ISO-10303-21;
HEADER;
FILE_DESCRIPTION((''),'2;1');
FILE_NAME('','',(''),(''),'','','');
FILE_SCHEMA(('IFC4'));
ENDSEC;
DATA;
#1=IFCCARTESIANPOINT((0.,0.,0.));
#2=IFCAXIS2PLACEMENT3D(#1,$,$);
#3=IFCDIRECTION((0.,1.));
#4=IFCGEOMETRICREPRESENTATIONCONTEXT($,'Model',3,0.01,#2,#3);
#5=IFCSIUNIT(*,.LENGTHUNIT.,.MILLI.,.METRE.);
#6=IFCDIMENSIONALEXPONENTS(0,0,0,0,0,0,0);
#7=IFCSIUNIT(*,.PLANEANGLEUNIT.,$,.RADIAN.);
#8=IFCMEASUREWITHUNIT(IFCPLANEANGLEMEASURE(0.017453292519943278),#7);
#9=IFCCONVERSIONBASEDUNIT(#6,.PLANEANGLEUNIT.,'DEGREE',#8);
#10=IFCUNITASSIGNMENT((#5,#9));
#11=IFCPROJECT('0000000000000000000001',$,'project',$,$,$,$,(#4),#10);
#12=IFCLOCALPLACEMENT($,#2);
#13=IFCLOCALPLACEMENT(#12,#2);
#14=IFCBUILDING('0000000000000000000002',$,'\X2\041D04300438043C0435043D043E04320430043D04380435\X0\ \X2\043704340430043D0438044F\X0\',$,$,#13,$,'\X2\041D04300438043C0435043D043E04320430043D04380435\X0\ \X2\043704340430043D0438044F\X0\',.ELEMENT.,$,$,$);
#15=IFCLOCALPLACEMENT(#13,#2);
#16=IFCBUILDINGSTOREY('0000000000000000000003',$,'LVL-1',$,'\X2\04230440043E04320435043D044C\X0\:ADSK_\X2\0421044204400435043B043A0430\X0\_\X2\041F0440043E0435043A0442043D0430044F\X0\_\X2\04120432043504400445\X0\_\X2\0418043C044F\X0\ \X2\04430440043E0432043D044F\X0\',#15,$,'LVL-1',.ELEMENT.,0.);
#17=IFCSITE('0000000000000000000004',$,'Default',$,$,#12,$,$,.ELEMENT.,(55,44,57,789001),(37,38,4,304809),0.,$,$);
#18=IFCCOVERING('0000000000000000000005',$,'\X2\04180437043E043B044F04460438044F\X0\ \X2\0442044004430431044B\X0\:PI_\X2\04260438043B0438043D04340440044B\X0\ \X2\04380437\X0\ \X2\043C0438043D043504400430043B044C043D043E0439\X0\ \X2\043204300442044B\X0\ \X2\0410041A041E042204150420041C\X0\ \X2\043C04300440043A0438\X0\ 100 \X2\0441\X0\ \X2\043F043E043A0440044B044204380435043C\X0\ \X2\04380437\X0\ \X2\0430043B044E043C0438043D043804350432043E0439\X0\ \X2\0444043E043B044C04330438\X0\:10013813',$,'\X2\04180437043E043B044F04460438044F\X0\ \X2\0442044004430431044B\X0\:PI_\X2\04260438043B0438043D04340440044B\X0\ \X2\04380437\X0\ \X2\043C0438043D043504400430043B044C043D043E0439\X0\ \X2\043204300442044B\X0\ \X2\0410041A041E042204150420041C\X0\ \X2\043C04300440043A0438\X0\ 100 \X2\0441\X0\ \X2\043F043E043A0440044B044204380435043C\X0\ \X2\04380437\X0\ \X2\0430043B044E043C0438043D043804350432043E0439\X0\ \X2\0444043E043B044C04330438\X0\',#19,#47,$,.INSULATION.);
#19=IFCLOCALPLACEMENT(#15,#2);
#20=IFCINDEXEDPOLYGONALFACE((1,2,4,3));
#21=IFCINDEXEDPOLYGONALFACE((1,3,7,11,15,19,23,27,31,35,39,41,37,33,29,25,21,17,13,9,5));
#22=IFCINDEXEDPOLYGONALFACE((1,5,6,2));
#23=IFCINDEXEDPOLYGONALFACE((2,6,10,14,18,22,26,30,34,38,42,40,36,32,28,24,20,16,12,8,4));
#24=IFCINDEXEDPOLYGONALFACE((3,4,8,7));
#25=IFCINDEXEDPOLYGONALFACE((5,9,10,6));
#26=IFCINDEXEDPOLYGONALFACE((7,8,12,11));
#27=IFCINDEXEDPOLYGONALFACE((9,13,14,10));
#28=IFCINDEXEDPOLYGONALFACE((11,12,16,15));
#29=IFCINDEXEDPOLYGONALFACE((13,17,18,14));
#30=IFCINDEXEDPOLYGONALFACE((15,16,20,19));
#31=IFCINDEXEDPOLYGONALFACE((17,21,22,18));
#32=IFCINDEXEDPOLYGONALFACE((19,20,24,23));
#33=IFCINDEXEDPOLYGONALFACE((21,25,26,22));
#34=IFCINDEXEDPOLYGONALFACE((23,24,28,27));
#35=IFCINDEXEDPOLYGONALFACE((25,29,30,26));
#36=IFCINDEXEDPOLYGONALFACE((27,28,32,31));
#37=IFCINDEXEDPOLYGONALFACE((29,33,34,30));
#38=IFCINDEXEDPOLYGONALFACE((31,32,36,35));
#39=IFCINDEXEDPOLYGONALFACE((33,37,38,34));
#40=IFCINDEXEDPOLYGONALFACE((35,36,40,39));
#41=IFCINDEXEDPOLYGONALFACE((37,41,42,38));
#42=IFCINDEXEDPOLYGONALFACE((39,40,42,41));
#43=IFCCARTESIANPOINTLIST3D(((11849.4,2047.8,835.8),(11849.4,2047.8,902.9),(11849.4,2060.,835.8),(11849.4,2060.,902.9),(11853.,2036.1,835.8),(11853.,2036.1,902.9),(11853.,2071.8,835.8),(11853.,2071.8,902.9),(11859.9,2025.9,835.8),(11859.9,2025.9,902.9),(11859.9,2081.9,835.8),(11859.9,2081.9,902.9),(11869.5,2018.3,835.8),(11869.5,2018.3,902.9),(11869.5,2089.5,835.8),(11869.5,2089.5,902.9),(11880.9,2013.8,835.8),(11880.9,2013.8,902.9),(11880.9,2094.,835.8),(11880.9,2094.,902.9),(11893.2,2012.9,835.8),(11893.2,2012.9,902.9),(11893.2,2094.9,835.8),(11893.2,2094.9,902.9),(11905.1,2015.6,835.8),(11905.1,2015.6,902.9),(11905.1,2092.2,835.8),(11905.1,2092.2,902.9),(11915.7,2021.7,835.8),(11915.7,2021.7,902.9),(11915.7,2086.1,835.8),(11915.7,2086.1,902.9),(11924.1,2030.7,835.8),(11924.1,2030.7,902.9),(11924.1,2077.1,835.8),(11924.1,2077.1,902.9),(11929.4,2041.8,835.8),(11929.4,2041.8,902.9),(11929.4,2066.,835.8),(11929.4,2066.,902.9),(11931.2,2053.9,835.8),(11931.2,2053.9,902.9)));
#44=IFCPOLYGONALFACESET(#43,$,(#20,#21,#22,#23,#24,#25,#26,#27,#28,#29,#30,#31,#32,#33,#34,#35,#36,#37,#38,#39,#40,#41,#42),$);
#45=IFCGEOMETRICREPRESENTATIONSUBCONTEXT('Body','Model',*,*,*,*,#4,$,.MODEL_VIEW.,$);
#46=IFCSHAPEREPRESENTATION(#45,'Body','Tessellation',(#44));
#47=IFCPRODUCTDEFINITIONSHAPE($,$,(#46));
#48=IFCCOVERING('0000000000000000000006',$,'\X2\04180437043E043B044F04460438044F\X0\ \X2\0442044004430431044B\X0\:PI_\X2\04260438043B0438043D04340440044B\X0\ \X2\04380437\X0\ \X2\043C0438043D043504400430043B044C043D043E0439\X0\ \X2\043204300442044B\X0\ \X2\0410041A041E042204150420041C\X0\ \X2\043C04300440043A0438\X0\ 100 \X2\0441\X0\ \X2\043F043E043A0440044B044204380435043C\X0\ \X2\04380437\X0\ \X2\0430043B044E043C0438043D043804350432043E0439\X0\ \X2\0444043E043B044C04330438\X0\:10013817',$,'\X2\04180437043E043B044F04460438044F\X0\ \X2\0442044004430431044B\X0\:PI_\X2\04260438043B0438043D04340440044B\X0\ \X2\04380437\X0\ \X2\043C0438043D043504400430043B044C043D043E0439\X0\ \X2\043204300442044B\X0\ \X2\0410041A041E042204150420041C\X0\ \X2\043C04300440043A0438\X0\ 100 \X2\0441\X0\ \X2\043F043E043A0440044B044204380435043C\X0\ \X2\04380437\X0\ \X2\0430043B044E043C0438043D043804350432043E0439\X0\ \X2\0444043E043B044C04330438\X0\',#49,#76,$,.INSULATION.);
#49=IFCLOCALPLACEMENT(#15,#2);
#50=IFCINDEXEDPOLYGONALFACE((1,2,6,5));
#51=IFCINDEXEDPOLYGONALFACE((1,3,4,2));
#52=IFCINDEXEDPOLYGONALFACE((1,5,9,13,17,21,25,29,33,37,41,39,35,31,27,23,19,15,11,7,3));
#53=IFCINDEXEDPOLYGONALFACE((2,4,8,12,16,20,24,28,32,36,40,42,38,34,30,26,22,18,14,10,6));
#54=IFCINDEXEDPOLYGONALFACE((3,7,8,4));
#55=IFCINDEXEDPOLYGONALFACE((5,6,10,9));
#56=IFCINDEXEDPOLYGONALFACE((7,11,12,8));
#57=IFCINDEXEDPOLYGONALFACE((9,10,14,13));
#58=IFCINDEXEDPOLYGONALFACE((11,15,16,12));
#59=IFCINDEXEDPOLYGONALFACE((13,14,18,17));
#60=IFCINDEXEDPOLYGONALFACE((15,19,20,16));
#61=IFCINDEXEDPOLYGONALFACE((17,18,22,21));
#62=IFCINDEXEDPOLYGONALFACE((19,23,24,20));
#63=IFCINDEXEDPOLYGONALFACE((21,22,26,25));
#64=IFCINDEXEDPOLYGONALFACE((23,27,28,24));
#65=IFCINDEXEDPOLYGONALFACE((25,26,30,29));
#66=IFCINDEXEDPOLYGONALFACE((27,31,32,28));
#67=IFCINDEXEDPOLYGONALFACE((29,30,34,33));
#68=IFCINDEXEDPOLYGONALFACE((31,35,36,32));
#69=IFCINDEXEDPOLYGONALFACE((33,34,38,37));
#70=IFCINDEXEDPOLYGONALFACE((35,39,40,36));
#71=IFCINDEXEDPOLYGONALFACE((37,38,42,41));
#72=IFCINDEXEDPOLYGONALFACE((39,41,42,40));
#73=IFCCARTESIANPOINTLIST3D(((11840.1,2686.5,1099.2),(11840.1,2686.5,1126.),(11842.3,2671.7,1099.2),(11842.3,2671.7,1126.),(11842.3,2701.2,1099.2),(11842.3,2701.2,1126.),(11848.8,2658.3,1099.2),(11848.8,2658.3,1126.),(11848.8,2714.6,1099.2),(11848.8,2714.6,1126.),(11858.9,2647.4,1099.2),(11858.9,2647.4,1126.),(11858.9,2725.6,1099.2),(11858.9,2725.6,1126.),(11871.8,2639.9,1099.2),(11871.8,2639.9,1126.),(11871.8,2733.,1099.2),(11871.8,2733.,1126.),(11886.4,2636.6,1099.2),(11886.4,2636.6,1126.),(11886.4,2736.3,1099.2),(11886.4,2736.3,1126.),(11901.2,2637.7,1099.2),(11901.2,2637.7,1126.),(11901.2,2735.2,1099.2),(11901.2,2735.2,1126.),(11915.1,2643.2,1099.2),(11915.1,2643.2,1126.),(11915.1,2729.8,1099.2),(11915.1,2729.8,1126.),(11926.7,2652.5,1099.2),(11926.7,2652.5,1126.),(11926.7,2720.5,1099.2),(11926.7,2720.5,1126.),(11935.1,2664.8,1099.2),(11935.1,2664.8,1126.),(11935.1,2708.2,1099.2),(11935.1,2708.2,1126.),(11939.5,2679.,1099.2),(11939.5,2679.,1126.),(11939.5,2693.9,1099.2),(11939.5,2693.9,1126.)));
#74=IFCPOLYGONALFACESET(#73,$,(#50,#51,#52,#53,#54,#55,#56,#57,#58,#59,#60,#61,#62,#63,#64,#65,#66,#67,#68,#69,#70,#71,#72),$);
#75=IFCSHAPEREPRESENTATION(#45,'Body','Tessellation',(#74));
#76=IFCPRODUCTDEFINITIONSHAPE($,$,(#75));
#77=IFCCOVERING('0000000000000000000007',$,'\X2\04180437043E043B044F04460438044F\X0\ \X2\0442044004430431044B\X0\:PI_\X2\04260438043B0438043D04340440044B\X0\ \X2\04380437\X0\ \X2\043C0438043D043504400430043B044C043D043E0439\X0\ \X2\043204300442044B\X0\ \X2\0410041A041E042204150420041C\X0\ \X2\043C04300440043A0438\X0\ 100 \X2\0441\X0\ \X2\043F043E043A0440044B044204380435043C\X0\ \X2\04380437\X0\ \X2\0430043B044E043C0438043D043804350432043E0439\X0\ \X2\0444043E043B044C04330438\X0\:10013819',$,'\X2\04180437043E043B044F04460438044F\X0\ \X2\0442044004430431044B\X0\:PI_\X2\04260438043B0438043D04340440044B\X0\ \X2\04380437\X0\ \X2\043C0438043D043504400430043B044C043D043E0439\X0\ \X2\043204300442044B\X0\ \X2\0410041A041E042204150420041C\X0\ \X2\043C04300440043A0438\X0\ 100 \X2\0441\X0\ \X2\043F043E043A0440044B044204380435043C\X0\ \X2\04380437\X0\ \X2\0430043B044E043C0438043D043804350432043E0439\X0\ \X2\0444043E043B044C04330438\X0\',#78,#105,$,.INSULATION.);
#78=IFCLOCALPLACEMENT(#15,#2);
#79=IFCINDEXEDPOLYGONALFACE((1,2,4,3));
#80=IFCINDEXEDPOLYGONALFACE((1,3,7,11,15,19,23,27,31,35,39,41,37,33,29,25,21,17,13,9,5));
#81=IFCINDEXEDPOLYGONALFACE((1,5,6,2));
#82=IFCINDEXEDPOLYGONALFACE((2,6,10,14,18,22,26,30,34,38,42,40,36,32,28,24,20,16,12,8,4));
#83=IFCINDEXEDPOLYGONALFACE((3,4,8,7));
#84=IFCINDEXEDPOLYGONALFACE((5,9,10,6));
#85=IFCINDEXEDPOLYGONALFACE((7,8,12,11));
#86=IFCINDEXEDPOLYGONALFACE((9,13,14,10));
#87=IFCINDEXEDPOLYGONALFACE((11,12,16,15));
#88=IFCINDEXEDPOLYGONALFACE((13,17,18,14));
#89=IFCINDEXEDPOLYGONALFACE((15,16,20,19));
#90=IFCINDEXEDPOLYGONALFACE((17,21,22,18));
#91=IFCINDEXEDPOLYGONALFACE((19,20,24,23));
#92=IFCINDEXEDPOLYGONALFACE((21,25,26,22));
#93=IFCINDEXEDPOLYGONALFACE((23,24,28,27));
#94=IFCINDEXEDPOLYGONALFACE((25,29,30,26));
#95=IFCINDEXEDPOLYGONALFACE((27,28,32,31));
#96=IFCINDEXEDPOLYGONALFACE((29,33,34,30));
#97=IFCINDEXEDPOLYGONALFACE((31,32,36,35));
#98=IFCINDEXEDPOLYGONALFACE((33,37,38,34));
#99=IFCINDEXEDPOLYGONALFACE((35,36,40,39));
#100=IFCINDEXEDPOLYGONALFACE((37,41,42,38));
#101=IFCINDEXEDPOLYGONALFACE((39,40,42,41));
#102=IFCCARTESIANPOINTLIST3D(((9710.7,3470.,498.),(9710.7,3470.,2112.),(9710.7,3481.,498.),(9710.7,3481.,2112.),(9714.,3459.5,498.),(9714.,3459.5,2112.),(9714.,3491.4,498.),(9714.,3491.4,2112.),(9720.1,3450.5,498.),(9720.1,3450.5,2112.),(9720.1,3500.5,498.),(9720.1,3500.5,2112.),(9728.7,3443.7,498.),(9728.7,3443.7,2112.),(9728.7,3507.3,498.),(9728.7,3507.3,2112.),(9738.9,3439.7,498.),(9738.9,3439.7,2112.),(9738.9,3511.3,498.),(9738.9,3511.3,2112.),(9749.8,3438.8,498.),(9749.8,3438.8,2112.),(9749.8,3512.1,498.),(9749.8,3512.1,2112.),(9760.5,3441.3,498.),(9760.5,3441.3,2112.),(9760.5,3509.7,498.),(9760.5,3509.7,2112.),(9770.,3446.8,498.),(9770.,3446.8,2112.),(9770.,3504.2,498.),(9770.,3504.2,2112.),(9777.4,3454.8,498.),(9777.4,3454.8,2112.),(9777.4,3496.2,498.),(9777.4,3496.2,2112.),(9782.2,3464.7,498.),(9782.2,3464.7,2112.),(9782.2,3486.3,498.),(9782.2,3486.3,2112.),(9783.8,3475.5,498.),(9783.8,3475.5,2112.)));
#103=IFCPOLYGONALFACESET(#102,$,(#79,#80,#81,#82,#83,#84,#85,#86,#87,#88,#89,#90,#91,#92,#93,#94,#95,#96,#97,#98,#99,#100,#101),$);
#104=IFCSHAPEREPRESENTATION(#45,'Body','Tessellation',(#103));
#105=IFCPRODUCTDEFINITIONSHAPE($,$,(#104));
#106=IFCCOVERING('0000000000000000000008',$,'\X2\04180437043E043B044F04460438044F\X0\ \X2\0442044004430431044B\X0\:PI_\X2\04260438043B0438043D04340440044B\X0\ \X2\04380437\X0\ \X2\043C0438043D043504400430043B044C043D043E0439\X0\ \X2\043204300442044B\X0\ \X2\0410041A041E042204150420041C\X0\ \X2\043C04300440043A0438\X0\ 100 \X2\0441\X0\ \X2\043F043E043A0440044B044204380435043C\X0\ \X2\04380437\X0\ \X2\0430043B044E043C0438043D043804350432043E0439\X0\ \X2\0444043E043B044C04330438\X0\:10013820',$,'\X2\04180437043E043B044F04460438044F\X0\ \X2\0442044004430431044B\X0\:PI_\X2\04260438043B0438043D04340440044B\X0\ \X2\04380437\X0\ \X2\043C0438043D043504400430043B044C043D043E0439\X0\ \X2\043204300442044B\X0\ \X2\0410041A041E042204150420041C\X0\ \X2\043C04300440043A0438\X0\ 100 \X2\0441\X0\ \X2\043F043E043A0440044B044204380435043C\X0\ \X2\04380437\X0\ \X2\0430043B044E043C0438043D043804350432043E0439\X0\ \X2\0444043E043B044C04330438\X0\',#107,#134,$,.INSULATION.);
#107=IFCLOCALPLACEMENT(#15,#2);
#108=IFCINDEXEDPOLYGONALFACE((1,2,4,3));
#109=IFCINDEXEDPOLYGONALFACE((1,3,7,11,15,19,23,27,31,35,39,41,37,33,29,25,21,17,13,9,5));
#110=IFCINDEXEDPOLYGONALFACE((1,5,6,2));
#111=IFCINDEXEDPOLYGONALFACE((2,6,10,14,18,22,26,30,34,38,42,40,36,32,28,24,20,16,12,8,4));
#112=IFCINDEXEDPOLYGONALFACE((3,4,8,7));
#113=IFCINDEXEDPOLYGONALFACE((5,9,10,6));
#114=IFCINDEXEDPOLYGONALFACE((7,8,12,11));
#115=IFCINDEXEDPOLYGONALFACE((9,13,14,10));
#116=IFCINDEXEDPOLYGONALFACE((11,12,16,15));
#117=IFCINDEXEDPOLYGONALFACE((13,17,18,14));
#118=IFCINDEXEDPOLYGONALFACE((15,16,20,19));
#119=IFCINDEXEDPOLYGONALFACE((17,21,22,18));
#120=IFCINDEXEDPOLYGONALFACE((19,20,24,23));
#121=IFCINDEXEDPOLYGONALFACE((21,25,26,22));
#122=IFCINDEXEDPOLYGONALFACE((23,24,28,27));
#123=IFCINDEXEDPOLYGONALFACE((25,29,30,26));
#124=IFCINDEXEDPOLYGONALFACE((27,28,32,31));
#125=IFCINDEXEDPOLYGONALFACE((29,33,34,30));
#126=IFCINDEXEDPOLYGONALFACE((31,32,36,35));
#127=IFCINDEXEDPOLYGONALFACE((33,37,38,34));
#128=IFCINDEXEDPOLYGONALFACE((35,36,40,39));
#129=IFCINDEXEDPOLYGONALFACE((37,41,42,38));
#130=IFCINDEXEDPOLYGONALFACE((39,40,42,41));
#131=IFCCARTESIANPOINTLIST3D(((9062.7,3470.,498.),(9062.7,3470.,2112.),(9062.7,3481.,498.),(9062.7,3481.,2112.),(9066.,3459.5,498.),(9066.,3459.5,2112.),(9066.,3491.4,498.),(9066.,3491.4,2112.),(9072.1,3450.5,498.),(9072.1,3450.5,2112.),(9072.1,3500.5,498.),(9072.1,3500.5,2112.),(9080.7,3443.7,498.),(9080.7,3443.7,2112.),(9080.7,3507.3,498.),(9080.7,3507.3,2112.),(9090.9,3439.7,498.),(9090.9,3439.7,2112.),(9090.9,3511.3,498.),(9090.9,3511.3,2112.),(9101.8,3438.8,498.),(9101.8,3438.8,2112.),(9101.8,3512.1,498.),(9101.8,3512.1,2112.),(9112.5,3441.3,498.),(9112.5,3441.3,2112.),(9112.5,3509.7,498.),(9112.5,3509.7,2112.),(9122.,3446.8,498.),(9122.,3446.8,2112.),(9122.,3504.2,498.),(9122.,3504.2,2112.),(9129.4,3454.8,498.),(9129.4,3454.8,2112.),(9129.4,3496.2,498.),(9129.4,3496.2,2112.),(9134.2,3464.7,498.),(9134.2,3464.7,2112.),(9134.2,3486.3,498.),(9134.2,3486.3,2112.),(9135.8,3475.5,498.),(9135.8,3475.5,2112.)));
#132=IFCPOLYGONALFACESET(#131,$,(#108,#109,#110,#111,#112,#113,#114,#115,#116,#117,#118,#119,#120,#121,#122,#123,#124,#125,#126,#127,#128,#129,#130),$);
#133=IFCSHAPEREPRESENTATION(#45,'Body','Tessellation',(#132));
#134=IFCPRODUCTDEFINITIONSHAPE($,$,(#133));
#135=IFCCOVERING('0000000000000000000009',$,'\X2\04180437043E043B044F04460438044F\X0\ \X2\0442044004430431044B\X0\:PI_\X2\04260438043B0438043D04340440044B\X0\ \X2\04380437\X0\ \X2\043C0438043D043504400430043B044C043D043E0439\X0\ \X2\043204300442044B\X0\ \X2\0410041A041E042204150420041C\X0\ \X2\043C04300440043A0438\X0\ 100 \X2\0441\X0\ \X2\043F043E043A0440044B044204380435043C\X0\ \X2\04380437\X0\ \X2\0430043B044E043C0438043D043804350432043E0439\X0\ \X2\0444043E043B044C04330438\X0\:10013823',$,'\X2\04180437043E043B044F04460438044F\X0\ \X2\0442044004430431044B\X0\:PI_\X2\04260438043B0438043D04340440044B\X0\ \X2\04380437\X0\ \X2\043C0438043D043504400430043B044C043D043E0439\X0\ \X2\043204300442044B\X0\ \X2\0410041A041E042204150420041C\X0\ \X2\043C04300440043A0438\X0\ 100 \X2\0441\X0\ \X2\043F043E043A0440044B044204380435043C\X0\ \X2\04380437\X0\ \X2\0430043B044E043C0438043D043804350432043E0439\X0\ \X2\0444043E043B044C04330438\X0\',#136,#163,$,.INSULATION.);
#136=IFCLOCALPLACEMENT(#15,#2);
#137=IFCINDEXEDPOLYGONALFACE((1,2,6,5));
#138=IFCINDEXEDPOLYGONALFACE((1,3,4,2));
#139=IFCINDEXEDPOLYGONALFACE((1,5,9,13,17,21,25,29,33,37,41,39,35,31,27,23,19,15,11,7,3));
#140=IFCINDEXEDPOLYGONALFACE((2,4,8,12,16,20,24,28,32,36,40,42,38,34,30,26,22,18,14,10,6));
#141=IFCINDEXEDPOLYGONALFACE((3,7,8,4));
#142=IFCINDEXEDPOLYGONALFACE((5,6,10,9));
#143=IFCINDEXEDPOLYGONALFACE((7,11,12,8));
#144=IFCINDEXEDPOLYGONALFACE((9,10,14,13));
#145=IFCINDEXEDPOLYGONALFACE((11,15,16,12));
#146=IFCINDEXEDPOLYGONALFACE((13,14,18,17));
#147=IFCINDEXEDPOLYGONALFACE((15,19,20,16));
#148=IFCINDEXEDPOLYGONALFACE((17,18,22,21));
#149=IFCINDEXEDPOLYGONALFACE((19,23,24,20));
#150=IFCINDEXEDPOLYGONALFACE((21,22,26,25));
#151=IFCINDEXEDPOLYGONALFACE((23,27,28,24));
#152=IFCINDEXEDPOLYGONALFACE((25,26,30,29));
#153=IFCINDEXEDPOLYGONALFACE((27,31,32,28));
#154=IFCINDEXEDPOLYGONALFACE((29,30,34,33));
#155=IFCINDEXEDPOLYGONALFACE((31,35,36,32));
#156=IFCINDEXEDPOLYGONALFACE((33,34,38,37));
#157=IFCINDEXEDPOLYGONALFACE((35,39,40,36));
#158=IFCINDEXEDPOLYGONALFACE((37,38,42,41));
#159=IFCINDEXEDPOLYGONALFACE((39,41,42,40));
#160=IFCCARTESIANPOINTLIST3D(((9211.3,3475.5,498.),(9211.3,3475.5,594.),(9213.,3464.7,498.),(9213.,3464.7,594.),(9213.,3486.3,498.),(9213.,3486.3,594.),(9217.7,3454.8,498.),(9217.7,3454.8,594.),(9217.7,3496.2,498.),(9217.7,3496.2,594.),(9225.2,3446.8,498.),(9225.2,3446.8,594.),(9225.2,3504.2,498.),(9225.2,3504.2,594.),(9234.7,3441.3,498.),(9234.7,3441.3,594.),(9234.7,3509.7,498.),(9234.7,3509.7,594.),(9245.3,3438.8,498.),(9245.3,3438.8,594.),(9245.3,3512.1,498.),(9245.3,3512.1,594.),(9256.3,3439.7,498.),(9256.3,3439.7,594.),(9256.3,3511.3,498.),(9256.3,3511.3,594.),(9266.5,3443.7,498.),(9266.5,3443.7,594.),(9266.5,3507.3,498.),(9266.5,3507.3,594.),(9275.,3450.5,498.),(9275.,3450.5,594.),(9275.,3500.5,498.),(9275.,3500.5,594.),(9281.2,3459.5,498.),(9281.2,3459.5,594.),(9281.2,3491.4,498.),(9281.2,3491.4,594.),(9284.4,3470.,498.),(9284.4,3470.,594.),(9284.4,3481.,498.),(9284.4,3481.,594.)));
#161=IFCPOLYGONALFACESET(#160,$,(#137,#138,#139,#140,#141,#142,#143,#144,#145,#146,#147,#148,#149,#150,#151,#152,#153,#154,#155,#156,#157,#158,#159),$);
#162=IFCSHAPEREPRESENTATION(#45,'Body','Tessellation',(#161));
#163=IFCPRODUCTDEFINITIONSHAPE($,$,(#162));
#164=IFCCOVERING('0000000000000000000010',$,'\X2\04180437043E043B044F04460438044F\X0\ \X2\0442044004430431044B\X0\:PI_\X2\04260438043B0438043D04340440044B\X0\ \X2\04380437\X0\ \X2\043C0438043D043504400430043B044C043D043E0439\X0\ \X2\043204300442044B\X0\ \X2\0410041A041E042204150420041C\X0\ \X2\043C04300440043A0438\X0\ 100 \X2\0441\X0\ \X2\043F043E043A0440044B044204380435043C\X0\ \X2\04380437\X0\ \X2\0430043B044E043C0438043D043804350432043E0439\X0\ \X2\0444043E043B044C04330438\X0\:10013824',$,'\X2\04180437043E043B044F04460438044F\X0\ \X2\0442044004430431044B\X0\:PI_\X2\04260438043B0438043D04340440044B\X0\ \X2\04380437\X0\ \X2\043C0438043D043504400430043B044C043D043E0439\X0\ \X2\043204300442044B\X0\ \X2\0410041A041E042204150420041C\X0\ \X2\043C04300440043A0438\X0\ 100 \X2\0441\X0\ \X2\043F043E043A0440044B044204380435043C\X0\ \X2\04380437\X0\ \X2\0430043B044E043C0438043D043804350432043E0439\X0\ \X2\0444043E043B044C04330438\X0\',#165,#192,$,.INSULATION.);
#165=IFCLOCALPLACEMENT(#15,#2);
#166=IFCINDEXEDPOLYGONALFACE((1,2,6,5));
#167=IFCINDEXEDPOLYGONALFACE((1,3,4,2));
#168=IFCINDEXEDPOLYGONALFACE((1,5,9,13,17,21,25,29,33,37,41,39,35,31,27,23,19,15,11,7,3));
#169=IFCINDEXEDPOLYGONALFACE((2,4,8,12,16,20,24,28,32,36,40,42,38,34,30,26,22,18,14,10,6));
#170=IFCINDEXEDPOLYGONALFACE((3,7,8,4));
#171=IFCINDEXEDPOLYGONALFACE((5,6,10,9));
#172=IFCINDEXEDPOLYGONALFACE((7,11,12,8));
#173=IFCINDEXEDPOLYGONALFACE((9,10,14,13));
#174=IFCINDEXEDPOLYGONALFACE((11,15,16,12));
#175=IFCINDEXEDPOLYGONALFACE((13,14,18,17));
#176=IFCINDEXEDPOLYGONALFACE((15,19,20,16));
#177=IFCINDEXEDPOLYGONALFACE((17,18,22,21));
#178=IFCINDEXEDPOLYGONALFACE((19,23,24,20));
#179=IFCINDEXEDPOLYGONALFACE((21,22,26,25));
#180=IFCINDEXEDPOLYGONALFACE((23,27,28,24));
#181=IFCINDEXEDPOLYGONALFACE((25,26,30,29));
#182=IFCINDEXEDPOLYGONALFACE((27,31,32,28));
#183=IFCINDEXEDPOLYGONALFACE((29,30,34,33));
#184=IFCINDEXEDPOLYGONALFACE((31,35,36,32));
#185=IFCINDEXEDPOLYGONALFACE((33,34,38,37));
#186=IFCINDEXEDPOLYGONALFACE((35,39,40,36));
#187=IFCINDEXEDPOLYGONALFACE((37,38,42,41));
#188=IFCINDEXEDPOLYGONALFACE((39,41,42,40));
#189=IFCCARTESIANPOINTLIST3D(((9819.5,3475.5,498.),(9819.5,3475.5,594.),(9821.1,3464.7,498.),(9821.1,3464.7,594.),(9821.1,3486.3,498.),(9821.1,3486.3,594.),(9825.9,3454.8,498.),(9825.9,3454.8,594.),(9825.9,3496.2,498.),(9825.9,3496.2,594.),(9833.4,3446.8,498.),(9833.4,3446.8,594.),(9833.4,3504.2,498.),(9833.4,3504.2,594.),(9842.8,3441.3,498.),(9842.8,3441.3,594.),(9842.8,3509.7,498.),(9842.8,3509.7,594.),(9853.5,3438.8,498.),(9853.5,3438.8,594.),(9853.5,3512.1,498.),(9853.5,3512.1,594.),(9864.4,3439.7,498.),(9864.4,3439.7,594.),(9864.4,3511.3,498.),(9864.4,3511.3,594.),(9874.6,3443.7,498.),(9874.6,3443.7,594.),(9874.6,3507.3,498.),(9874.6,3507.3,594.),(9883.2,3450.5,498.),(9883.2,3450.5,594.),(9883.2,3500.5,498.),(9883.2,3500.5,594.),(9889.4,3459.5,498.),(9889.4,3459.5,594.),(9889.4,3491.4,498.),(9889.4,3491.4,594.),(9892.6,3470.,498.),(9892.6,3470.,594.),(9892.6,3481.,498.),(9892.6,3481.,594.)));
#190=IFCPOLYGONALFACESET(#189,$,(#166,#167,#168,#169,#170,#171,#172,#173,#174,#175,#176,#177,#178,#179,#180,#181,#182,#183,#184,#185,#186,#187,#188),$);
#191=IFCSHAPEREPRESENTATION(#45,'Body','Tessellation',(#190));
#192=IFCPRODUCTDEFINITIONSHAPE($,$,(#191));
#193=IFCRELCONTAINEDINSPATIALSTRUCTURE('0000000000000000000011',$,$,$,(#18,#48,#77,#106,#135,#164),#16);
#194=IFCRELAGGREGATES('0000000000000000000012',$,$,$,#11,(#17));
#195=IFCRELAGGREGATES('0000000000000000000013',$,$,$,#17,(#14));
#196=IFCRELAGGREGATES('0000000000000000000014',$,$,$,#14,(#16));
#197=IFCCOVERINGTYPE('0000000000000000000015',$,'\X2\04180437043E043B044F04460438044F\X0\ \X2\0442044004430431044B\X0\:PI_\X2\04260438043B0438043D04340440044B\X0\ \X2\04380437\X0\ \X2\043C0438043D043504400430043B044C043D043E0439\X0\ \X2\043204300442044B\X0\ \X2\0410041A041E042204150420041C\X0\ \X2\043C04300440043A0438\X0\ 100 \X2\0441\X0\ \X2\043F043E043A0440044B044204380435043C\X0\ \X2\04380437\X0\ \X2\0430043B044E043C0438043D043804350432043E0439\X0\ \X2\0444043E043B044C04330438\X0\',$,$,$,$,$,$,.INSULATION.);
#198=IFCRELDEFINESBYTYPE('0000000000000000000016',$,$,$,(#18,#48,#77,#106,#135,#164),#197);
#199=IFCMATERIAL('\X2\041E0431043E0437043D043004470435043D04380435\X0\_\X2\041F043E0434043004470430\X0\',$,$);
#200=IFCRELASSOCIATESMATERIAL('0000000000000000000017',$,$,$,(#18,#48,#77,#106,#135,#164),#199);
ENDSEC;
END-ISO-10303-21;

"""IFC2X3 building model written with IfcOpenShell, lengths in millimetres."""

from ifc_helpers import new_model, entity, si_unit, converted_unit, direction, frame, frame_2d, origin, origin_2d_with_axis, place, context, subcontext, project, spatial, circle, extrude, material, type_object, element, save


model = new_model("IFC2X3")

# Units and contexts
model_context = context("Model", 3, precision=0.01, world=origin(), true_north=direction((0.0, 1.0)))
body_context = subcontext(model_context, "Body", "Model", "MODEL_VIEW")
ifc_project = project(units=[si_unit("LENGTHUNIT", "METRE", prefix="MILLI"), converted_unit("PLANEANGLEUNIT", "DEGREE", entity("IfcPlaneAngleMeasure", 0.017453292519943278), si_unit("PLANEANGLEUNIT", "RADIAN"), dimensions=[0, 0, 0, 0, 0, 0, 0])], contexts=[model_context])

# Site, building, storey
site_placement = place(None, origin())
site = spatial("IfcSite", under=ifc_project, at=site_placement, Name="Default", CompositionType="ELEMENT", RefLatitude=(55, 44, 57, 789001), RefLongitude=(37, 38, 4, 304809), RefElevation=0.0)
building_placement = place(site_placement, origin())
building = spatial("IfcBuilding", under=site, at=building_placement, Name="Наименование здания", LongName="Наименование здания", CompositionType="ELEMENT")
storey_placement = place(building_placement, origin())
storey = spatial("IfcBuildingStorey", under=building, at=storey_placement, Name="LVL-1", ObjectType="Уровень:ADSK_Стрелка_Проектная_Вверх_Имя уровня", LongName="LVL-1", CompositionType="ELEMENT", Elevation=0.0)

# Coverings
ifc_material_1 = material(Name="Обозначение_Подача")
covering_type = type_object("IfcCoveringType", Name="Изоляция трубы:PI_Цилиндры из минеральной ваты АКОТЕРМ марки 100 с покрытием из алюминиевой фольги", PredefinedType="INSULATION")
covering_1_placement = place(storey_placement, origin())
element("IfcCovering", 1, at=covering_1_placement, inside=storey, type_object=covering_type, material=ifc_material_1, Name="Изоляция трубы:PI_Цилиндры из минеральной ваты АКОТЕРМ марки 100 с покрытием из алюминиевой фольги:10013813", ObjectType="Изоляция трубы:PI_Цилиндры из минеральной ваты АКОТЕРМ марки 100 с покрытием из алюминиевой фольги", PredefinedType="INSULATION", context=body_context, shape_type="SweptSolid", body=[
    extrude(circle(Radius=41.1, at=frame_2d((0.0, 0.0), x_axis=(1.0, 0.0))), frame((11890.1, 2053.9, 835.8)), (0.0, 0.0, 1.0), 67.1),
])
covering_2_placement = place(storey_placement, origin())
element("IfcCovering", 2, at=covering_2_placement, inside=storey, type_object=covering_type, material=ifc_material_1, Name="Изоляция трубы:PI_Цилиндры из минеральной ваты АКОТЕРМ марки 100 с покрытием из алюминиевой фольги:10013817", ObjectType="Изоляция трубы:PI_Цилиндры из минеральной ваты АКОТЕРМ марки 100 с покрытием из алюминиевой фольги", PredefinedType="INSULATION", context=body_context, shape_type="SweptSolid", body=[
    extrude(circle(Radius=50.0, at=frame_2d((0.0, 0.0), x_axis=(1.0, 0.0))), frame((11890.1, 2686.5, 1099.2), z_axis=(0.0, 0.0, 1.0), x_axis=(-1.0, 0.0, 0.0)), (0.0, 0.0, 1.0), 26.8),
])
covering_3_placement = place(storey_placement, origin())
element("IfcCovering", 3, at=covering_3_placement, inside=storey, type_object=covering_type, material=ifc_material_1, Name="Изоляция трубы:PI_Цилиндры из минеральной ваты АКОТЕРМ марки 100 с покрытием из алюминиевой фольги:10013819", ObjectType="Изоляция трубы:PI_Цилиндры из минеральной ваты АКОТЕРМ марки 100 с покрытием из алюминиевой фольги", PredefinedType="INSULATION", context=body_context, shape_type="SweptSolid", body=[
    extrude(circle(Radius=36.8, at=frame_2d((0.0, 0.0), x_axis=(1.0, 0.0))), frame((9747.1, 3475.5, 498.0)), (0.0, 0.0, 1.0), 1614.0),
])
covering_4_placement = place(storey_placement, origin())
element("IfcCovering", 4, at=covering_4_placement, inside=storey, type_object=covering_type, material=ifc_material_1, Name="Изоляция трубы:PI_Цилиндры из минеральной ваты АКОТЕРМ марки 100 с покрытием из алюминиевой фольги:10013820", ObjectType="Изоляция трубы:PI_Цилиндры из минеральной ваты АКОТЕРМ марки 100 с покрытием из алюминиевой фольги", PredefinedType="INSULATION", context=body_context, shape_type="SweptSolid", body=[
    extrude(circle(Radius=36.8, at=frame_2d((0.0, 0.0), x_axis=(1.0, 0.0))), frame((9099.1, 3475.5, 498.0)), (0.0, 0.0, 1.0), 1614.0),
])
covering_5_placement = place(storey_placement, origin())
element("IfcCovering", 5, at=covering_5_placement, inside=storey, type_object=covering_type, material=ifc_material_1, Name="Изоляция трубы:PI_Цилиндры из минеральной ваты АКОТЕРМ марки 100 с покрытием из алюминиевой фольги:10013823", ObjectType="Изоляция трубы:PI_Цилиндры из минеральной ваты АКОТЕРМ марки 100 с покрытием из алюминиевой фольги", PredefinedType="INSULATION", context=body_context, shape_type="SweptSolid", body=[
    extrude(circle(Radius=36.8, at=origin_2d_with_axis()), frame((9248.1, 3475.5, 498.0), z_axis=(0.0, 0.0, 1.0), x_axis=(-1.0, 0.0, 0.0)), (0.0, 0.0, 1.0), 96.0),
])
covering_6_placement = place(storey_placement, origin())
element("IfcCovering", 6, at=covering_6_placement, inside=storey, type_object=covering_type, material=ifc_material_1, Name="Изоляция трубы:PI_Цилиндры из минеральной ваты АКОТЕРМ марки 100 с покрытием из алюминиевой фольги:10013824", ObjectType="Изоляция трубы:PI_Цилиндры из минеральной ваты АКОТЕРМ марки 100 с покрытием из алюминиевой фольги", PredefinedType="INSULATION", context=body_context, shape_type="SweptSolid", body=[
    extrude(circle(Radius=36.8, at=frame_2d((0.0, 0.0), x_axis=(1.0, 0.0))), frame((9856.3, 3475.5, 498.0), z_axis=(0.0, 0.0, 1.0), x_axis=(-1.0, 0.0, 0.0)), (0.0, 0.0, 1.0), 96.0),
])

save(model, "model.ifc")
